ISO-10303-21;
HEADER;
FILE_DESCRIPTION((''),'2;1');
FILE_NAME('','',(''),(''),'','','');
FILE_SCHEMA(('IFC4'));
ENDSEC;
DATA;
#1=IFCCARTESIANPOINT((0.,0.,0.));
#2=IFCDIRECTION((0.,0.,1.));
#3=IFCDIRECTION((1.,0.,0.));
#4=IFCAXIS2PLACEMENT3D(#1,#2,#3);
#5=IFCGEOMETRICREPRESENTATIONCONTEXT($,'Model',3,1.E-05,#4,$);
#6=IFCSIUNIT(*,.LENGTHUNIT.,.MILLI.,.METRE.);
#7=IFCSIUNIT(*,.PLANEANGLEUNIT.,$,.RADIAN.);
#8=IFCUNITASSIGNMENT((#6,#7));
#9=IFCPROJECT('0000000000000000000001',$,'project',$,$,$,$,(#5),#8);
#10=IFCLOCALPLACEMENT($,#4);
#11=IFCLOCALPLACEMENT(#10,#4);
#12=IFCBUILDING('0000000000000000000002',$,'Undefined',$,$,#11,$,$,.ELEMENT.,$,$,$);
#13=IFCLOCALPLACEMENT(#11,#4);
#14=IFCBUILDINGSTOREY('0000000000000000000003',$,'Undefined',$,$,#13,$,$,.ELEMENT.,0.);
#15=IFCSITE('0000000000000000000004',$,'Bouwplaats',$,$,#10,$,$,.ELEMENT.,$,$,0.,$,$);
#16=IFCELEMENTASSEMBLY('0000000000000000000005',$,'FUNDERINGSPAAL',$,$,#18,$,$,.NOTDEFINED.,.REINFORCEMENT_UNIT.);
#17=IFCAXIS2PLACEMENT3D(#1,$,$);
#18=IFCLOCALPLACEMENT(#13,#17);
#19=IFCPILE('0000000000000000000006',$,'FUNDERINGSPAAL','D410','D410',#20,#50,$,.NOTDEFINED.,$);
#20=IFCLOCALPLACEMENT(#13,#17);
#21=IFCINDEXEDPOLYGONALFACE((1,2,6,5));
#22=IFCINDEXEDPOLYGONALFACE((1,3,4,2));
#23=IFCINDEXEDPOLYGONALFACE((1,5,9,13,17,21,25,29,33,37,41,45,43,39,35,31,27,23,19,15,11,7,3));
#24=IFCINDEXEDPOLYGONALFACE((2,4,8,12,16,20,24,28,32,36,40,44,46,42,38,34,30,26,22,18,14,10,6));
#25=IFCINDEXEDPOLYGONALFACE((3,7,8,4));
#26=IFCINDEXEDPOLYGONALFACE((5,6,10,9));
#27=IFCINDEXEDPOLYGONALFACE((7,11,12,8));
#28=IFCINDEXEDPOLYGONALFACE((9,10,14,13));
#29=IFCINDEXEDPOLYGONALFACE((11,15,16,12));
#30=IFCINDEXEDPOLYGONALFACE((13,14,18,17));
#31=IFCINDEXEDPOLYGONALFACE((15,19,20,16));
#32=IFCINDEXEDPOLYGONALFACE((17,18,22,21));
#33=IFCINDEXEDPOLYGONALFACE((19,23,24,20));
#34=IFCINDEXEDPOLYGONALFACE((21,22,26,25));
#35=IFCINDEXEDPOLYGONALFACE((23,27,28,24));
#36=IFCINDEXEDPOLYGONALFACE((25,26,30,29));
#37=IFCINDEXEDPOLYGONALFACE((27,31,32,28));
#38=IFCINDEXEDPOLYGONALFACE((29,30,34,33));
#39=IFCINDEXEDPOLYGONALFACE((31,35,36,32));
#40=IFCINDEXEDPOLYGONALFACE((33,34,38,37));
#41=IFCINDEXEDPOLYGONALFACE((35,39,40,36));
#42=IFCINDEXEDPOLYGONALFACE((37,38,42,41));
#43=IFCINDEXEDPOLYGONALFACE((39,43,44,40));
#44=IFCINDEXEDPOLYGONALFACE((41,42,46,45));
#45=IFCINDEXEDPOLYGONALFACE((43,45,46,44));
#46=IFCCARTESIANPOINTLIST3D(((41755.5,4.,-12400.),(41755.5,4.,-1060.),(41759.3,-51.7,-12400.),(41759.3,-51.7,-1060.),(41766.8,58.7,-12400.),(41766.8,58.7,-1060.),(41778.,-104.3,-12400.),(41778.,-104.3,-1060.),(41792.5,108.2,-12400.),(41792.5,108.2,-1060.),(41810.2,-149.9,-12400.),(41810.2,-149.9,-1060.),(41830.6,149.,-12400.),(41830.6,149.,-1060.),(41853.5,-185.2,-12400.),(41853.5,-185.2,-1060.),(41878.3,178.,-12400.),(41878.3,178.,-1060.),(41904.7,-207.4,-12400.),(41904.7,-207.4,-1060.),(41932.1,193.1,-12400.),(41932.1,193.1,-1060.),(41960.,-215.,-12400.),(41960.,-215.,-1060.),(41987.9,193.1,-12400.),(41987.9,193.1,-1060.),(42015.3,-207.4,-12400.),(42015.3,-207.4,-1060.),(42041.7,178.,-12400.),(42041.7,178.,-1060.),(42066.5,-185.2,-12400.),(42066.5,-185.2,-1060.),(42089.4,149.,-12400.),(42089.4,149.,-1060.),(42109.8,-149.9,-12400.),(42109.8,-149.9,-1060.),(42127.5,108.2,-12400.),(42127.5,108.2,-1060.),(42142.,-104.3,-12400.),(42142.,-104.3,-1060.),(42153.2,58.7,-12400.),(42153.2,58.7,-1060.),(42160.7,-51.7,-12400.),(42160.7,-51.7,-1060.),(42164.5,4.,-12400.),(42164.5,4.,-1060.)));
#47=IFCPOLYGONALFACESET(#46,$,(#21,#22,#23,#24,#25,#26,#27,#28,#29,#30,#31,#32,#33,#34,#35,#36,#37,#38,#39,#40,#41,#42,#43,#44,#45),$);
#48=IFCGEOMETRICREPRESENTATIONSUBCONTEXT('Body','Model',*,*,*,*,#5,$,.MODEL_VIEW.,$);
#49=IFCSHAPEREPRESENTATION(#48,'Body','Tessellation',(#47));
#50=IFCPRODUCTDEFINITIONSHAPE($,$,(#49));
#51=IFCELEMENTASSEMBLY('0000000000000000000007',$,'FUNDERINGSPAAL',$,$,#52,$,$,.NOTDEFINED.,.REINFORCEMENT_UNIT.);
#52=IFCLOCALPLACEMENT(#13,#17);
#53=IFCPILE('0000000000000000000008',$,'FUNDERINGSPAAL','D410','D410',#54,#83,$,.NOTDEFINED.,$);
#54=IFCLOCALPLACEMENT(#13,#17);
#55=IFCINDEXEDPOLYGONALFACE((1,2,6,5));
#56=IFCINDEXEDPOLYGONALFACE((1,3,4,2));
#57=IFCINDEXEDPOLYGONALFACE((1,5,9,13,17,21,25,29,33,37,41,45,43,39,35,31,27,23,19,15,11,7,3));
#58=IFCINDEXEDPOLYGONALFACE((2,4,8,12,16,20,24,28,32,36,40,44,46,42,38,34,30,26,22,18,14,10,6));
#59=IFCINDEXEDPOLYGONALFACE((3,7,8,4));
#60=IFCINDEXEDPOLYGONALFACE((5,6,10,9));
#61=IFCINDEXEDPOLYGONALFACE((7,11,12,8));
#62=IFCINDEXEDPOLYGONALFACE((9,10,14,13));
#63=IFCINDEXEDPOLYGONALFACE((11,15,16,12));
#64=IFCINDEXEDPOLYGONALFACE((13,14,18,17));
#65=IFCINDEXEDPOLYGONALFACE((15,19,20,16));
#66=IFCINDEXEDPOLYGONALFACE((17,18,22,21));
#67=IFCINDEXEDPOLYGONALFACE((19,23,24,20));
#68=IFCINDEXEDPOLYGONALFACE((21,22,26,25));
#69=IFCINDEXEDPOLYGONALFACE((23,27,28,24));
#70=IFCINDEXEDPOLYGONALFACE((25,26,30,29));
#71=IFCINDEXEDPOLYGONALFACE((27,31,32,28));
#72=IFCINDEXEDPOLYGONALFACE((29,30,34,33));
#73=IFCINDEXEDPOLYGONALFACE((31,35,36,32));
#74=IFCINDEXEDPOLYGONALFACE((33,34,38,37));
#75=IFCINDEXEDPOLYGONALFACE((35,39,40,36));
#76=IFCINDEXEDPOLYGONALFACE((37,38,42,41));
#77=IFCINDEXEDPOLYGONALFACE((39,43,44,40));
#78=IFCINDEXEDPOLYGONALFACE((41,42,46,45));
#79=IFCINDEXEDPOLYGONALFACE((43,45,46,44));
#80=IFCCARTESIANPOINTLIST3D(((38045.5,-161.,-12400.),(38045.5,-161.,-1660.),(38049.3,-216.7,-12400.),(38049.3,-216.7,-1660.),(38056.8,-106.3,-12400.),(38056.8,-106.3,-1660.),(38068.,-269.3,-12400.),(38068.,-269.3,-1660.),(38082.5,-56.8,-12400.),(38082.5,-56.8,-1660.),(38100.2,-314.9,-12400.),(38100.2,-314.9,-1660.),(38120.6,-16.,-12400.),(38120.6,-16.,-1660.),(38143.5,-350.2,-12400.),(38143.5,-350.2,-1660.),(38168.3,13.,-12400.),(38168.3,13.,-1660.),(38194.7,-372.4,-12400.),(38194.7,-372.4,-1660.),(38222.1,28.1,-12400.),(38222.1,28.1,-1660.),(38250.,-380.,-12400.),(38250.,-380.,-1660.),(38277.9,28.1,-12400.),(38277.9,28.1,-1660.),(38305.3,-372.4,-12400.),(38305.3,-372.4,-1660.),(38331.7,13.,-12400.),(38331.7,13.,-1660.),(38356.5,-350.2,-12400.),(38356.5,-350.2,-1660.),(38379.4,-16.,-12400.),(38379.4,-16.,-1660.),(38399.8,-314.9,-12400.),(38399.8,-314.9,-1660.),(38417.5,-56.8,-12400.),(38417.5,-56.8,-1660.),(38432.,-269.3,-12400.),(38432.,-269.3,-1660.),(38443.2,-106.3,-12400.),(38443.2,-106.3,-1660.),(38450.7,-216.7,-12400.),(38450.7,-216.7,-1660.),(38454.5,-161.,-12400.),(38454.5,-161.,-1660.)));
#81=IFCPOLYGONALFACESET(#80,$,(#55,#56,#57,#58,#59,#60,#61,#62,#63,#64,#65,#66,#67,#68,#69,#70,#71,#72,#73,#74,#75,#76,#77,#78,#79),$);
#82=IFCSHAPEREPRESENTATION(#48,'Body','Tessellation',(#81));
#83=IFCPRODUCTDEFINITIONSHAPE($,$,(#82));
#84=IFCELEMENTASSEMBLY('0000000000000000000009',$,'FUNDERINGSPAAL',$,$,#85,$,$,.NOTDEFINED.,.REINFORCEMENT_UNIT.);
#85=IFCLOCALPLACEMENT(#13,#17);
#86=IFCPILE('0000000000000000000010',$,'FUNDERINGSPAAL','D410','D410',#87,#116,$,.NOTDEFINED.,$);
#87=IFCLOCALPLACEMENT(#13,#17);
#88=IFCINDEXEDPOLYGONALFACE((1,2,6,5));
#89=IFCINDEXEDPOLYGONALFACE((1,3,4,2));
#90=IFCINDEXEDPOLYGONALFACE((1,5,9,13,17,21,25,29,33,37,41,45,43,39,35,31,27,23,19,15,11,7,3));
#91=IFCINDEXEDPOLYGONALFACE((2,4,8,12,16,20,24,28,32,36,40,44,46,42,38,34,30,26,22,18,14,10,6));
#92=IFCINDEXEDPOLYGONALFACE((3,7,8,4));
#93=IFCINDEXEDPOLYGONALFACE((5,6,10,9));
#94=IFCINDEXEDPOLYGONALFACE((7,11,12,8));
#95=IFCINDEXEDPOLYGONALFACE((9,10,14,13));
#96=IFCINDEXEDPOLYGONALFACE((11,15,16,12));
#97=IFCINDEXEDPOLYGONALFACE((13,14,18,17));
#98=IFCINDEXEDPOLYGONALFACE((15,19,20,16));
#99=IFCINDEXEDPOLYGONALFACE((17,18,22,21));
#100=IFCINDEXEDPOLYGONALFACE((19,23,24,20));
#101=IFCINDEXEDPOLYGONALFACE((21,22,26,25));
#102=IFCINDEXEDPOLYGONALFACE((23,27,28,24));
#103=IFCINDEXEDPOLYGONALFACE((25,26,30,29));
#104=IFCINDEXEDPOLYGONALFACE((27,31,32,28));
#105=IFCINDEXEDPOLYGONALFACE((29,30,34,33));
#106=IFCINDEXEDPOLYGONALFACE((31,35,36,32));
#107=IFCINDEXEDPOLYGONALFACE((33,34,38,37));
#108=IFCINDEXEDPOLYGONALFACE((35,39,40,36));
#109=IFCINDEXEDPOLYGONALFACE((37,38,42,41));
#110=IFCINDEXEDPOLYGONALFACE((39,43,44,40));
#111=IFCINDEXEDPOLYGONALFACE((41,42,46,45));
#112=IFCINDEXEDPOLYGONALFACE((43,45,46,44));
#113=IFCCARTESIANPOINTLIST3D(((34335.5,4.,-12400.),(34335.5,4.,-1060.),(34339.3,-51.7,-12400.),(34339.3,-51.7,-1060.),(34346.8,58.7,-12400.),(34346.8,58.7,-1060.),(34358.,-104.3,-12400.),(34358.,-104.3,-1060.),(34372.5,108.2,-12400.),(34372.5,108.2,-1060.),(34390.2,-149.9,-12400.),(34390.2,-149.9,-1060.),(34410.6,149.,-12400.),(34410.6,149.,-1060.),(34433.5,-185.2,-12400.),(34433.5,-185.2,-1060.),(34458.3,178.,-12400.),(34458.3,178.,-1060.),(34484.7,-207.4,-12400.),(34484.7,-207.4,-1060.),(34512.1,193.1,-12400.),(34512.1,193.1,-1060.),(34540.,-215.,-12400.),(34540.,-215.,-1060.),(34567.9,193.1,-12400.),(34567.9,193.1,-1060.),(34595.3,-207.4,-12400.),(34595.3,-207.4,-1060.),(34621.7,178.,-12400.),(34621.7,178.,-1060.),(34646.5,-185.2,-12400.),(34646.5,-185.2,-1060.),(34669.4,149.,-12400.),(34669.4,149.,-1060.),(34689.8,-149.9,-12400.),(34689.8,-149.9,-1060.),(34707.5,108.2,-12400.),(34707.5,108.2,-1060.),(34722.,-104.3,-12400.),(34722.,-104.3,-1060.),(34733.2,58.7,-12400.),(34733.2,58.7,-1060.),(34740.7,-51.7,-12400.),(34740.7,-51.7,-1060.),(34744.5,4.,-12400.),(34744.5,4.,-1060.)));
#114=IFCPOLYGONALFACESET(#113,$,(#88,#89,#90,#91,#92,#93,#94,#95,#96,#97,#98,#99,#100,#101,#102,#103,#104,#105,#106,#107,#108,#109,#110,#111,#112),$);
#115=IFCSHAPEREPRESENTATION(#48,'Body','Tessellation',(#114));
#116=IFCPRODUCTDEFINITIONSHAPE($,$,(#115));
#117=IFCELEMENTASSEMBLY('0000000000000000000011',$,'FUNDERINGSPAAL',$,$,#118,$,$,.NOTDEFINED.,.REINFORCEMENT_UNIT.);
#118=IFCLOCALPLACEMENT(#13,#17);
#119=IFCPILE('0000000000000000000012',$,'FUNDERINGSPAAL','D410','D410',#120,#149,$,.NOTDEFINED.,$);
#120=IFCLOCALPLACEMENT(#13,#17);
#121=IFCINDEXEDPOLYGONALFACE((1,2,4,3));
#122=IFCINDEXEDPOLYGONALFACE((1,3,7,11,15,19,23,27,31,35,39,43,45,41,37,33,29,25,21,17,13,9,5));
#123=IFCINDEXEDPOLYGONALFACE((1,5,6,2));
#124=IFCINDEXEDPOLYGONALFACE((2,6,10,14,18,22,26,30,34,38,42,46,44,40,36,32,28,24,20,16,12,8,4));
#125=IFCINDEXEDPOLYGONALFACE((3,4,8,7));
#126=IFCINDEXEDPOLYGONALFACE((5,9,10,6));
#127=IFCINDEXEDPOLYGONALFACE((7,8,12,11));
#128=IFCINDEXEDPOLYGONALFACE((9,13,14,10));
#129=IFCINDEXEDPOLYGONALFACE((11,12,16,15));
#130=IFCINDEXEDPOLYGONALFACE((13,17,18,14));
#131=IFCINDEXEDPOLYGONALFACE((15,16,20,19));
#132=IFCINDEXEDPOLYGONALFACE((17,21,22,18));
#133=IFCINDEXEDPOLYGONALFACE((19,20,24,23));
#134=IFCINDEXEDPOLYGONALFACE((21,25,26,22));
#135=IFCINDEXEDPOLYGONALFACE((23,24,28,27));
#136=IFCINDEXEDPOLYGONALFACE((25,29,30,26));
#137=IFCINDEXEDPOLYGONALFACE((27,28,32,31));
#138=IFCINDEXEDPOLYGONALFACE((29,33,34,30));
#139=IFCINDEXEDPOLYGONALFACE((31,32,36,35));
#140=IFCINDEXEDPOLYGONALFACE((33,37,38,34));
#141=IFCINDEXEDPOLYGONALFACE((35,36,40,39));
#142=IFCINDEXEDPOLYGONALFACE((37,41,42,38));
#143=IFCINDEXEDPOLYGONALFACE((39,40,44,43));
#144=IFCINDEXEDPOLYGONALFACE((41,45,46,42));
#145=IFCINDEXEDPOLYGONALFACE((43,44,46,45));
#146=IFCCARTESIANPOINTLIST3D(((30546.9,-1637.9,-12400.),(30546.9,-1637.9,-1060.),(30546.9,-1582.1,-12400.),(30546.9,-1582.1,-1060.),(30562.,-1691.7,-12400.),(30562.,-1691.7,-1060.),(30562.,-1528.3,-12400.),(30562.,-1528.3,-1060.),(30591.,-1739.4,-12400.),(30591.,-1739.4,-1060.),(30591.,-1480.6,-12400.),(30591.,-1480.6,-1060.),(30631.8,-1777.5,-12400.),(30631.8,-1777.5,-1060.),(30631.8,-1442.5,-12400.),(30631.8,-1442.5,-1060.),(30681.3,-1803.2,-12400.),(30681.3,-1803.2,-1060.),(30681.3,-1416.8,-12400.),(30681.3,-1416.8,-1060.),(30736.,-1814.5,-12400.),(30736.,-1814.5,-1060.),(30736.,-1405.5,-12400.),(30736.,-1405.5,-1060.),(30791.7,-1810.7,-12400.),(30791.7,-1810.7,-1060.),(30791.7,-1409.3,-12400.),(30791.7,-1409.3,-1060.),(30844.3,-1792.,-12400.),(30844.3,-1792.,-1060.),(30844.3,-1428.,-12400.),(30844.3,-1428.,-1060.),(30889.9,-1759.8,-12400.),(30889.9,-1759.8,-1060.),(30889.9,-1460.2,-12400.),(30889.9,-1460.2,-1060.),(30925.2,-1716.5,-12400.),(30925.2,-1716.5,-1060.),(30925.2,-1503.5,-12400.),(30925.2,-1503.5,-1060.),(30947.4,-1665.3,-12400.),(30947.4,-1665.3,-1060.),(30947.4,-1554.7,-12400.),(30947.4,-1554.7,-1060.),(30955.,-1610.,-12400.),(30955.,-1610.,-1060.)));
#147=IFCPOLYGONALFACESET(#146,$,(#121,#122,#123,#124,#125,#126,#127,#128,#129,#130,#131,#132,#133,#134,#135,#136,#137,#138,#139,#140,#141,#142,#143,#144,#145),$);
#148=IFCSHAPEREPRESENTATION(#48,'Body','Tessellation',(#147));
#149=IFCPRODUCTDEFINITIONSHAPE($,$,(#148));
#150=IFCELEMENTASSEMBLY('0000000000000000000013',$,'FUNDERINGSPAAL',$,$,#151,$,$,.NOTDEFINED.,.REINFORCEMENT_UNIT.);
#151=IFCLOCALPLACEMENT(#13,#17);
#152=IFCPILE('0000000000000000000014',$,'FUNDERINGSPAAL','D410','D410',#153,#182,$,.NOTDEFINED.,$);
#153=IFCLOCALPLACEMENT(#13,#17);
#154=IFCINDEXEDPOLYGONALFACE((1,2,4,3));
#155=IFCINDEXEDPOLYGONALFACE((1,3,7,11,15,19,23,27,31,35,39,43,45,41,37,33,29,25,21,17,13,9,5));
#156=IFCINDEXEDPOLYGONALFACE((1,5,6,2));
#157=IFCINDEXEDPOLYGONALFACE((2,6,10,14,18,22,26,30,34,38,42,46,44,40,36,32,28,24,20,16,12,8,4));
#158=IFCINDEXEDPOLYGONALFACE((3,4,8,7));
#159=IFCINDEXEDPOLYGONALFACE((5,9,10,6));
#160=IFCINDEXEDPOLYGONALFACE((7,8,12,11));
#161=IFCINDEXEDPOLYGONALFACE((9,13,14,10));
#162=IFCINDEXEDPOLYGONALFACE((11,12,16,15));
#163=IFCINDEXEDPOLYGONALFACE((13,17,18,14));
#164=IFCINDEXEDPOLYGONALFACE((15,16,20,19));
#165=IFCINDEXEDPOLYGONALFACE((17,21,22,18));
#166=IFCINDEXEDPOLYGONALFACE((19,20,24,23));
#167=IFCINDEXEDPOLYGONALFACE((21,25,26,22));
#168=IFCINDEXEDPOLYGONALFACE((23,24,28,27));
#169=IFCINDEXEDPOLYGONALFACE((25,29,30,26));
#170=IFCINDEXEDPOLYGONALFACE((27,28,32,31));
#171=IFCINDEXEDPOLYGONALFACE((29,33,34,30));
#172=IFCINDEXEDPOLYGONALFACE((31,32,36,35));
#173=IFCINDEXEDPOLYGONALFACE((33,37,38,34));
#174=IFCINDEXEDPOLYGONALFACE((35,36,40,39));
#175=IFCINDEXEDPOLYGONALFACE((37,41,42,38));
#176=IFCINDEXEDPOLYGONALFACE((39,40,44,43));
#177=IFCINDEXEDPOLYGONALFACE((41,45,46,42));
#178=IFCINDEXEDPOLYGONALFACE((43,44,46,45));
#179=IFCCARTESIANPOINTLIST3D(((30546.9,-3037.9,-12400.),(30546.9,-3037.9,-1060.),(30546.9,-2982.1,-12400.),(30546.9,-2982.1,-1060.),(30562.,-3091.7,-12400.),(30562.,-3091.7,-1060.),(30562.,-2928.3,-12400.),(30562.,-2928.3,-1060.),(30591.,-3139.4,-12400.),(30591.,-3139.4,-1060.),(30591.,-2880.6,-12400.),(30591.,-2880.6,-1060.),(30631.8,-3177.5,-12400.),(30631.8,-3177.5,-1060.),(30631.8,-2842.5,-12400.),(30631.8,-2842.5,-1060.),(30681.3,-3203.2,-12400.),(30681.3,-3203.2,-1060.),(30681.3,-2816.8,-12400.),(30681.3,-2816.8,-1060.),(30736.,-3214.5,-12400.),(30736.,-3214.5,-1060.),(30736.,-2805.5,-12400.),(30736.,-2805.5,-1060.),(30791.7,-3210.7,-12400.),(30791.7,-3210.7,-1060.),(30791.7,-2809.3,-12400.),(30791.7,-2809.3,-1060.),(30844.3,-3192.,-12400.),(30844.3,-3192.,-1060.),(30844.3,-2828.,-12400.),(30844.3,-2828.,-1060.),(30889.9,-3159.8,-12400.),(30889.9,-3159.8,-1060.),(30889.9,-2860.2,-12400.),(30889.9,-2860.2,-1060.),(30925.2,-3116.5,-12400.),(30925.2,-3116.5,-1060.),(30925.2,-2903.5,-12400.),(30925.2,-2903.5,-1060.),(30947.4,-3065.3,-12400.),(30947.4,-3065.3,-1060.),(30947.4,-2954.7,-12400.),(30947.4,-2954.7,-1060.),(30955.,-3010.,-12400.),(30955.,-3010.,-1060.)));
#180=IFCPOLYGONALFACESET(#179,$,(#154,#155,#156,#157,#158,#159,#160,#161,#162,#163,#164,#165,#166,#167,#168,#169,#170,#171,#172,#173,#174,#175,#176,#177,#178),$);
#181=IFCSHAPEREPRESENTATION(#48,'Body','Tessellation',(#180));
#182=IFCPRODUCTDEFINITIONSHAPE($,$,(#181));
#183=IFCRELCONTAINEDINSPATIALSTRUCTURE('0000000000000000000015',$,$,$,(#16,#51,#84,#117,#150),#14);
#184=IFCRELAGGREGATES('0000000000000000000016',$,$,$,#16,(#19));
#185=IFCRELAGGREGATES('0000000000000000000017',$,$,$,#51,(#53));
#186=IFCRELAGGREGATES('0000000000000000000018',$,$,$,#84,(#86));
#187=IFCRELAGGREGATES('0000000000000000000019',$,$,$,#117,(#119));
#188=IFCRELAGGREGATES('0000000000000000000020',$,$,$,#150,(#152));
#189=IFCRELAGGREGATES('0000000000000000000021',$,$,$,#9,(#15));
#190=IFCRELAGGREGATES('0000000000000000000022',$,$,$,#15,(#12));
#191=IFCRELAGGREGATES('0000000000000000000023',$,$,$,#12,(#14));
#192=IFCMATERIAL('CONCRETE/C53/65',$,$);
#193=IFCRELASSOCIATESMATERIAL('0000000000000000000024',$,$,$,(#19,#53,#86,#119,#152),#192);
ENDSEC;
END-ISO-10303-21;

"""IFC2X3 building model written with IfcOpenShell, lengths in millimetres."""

from ifc_helpers import new_model, si_unit, frame, origin_with_axes, origin_2d_with_axis, place, context, subcontext, project, spatial, circle, extrude, clip, halfspace, material, element, aggregate, save


model = new_model("IFC2X3")

# Units and contexts
model_context = context("Model", 3, precision=1e-05, world=origin_with_axes())
body_context = subcontext(model_context, "Body", "Model", "MODEL_VIEW")
ifc_project = project(units=[si_unit("LENGTHUNIT", "METRE", prefix="MILLI"), si_unit("PLANEANGLEUNIT", "RADIAN")], contexts=[model_context])

# Site, building, storey
site_placement = place(None, origin_with_axes())
site = spatial("IfcSite", under=ifc_project, at=site_placement, Name="Bouwplaats", CompositionType="ELEMENT", RefElevation=0.0)
building_placement = place(site_placement, origin_with_axes())
building = spatial("IfcBuilding", under=site, at=building_placement, Name="Undefined", CompositionType="ELEMENT")
storey_placement = place(building_placement, origin_with_axes())
storey = spatial("IfcBuildingStorey", under=building, at=storey_placement, Name="Undefined", CompositionType="ELEMENT", Elevation=0.0)

# Element assemblies, piles
ifc_material_1 = material(Name="CONCRETE/C53/65")
assembly_1_placement = place(storey_placement, origin_with_axes())
assembly_1 = element("IfcElementAssembly", 1, at=assembly_1_placement, inside=storey, Name="FUNDERINGSPAAL", AssemblyPlace="NOTDEFINED", PredefinedType="REINFORCEMENT_UNIT")
pile_1_placement = place(assembly_1_placement, frame((41960.0, -10.0, -1060.0), z_axis=(1.0, 0.0, 0.0), x_axis=(0.0, 0.0, -1.0)))
pile_1 = element("IfcPile", 2, at=pile_1_placement, material=ifc_material_1, Name="FUNDERINGSPAAL", Description="D410", ObjectType="D410", PredefinedType="NOTDEFINED", context=body_context, shape_type="Clipping", body=[
    clip(extrude(circle(Radius=205.0, at=origin_2d_with_axis()), frame((11340.0, 0.0, 0.0), z_axis=(-1.0, 0.0, 0.0), x_axis=(0.0, -1.0, 0.0)), (0.0, 0.0, 1.0), 11340.0), halfspace(frame((0.0, 205.0, -205.0), z_axis=(-1.0, 0.0, 0.0), x_axis=(0.0, 0.0, 1.0)), False)),
])
aggregate(assembly_1, [pile_1])
assembly_2_placement = place(storey_placement, origin_with_axes())
assembly_2 = element("IfcElementAssembly", 3, at=assembly_2_placement, inside=storey, Name="FUNDERINGSPAAL", AssemblyPlace="NOTDEFINED", PredefinedType="REINFORCEMENT_UNIT")
pile_2_placement = place(assembly_2_placement, frame((38250.0, -175.0, -1660.0), z_axis=(1.0, 0.0, 0.0), x_axis=(0.0, 0.0, -1.0)))
pile_2 = element("IfcPile", 4, at=pile_2_placement, material=ifc_material_1, Name="FUNDERINGSPAAL", Description="D410", ObjectType="D410", PredefinedType="NOTDEFINED", context=body_context, shape_type="Clipping", body=[
    clip(extrude(circle(Radius=205.0, at=origin_2d_with_axis()), frame((10740.0, 0.0, 0.0), z_axis=(-1.0, 0.0, 0.0), x_axis=(0.0, -1.0, 0.0)), (0.0, 0.0, 1.0), 10740.0), halfspace(frame((0.0, 205.0, -205.0), z_axis=(-1.0, 0.0, 0.0), x_axis=(0.0, 0.0, 1.0)), False)),
])
aggregate(assembly_2, [pile_2])
assembly_3_placement = place(storey_placement, origin_with_axes())
assembly_3 = element("IfcElementAssembly", 5, at=assembly_3_placement, inside=storey, Name="FUNDERINGSPAAL", AssemblyPlace="NOTDEFINED", PredefinedType="REINFORCEMENT_UNIT")
pile_3_placement = place(assembly_3_placement, frame((34540.0, -10.0, -1060.0), z_axis=(1.0, 0.0, 0.0), x_axis=(0.0, 0.0, -1.0)))
pile_3 = element("IfcPile", 6, at=pile_3_placement, material=ifc_material_1, Name="FUNDERINGSPAAL", Description="D410", ObjectType="D410", PredefinedType="NOTDEFINED", context=body_context, shape_type="Clipping", body=[
    clip(extrude(circle(Radius=205.0, at=origin_2d_with_axis()), frame((11340.0, 0.0, 0.0), z_axis=(-1.0, 0.0, 0.0), x_axis=(0.0, -1.0, 0.0)), (0.0, 0.0, 1.0), 11340.0), halfspace(frame((0.0, 205.0, -205.0), z_axis=(-1.0, 0.0, 0.0), x_axis=(0.0, 0.0, 1.0)), False)),
])
aggregate(assembly_3, [pile_3])
assembly_4_placement = place(storey_placement, origin_with_axes())
assembly_4 = element("IfcElementAssembly", 7, at=assembly_4_placement, inside=storey, Name="FUNDERINGSPAAL", AssemblyPlace="NOTDEFINED", PredefinedType="REINFORCEMENT_UNIT")
pile_4_placement = place(assembly_4_placement, frame((30750.0, -1610.0, -1060.0), z_axis=(0.0, 1.0, 0.0), x_axis=(0.0, 0.0, -1.0)))
pile_4 = element("IfcPile", 8, at=pile_4_placement, material=ifc_material_1, Name="FUNDERINGSPAAL", Description="D410", ObjectType="D410", PredefinedType="NOTDEFINED", context=body_context, shape_type="Clipping", body=[
    clip(extrude(circle(Radius=205.0, at=origin_2d_with_axis()), frame((11340.0, 0.0, 0.0), z_axis=(-1.0, 0.0, 0.0), x_axis=(0.0, -1.0, 0.0)), (0.0, 0.0, 1.0), 11340.0), halfspace(frame((0.0, 205.0, -205.0), z_axis=(-1.0, 0.0, 0.0), x_axis=(0.0, 0.0, 1.0)), False)),
])
aggregate(assembly_4, [pile_4])
assembly_5_placement = place(storey_placement, origin_with_axes())
assembly_5 = element("IfcElementAssembly", 9, at=assembly_5_placement, inside=storey, Name="FUNDERINGSPAAL", AssemblyPlace="NOTDEFINED", PredefinedType="REINFORCEMENT_UNIT")
pile_5_placement = place(assembly_5_placement, frame((30750.0, -3010.0, -1060.0), z_axis=(0.0, 1.0, 0.0), x_axis=(0.0, 0.0, -1.0)))
pile_5 = element("IfcPile", 10, at=pile_5_placement, material=ifc_material_1, Name="FUNDERINGSPAAL", Description="D410", ObjectType="D410", PredefinedType="NOTDEFINED", context=body_context, shape_type="Clipping", body=[
    clip(extrude(circle(Radius=205.0, at=origin_2d_with_axis()), frame((11340.0, 0.0, 0.0), z_axis=(-1.0, 0.0, 0.0), x_axis=(0.0, -1.0, 0.0)), (0.0, 0.0, 1.0), 11340.0), halfspace(frame((0.0, 205.0, -205.0), z_axis=(-1.0, 0.0, 0.0), x_axis=(0.0, 0.0, 1.0)), False)),
])
aggregate(assembly_5, [pile_5])

save(model, "model.ifc")
